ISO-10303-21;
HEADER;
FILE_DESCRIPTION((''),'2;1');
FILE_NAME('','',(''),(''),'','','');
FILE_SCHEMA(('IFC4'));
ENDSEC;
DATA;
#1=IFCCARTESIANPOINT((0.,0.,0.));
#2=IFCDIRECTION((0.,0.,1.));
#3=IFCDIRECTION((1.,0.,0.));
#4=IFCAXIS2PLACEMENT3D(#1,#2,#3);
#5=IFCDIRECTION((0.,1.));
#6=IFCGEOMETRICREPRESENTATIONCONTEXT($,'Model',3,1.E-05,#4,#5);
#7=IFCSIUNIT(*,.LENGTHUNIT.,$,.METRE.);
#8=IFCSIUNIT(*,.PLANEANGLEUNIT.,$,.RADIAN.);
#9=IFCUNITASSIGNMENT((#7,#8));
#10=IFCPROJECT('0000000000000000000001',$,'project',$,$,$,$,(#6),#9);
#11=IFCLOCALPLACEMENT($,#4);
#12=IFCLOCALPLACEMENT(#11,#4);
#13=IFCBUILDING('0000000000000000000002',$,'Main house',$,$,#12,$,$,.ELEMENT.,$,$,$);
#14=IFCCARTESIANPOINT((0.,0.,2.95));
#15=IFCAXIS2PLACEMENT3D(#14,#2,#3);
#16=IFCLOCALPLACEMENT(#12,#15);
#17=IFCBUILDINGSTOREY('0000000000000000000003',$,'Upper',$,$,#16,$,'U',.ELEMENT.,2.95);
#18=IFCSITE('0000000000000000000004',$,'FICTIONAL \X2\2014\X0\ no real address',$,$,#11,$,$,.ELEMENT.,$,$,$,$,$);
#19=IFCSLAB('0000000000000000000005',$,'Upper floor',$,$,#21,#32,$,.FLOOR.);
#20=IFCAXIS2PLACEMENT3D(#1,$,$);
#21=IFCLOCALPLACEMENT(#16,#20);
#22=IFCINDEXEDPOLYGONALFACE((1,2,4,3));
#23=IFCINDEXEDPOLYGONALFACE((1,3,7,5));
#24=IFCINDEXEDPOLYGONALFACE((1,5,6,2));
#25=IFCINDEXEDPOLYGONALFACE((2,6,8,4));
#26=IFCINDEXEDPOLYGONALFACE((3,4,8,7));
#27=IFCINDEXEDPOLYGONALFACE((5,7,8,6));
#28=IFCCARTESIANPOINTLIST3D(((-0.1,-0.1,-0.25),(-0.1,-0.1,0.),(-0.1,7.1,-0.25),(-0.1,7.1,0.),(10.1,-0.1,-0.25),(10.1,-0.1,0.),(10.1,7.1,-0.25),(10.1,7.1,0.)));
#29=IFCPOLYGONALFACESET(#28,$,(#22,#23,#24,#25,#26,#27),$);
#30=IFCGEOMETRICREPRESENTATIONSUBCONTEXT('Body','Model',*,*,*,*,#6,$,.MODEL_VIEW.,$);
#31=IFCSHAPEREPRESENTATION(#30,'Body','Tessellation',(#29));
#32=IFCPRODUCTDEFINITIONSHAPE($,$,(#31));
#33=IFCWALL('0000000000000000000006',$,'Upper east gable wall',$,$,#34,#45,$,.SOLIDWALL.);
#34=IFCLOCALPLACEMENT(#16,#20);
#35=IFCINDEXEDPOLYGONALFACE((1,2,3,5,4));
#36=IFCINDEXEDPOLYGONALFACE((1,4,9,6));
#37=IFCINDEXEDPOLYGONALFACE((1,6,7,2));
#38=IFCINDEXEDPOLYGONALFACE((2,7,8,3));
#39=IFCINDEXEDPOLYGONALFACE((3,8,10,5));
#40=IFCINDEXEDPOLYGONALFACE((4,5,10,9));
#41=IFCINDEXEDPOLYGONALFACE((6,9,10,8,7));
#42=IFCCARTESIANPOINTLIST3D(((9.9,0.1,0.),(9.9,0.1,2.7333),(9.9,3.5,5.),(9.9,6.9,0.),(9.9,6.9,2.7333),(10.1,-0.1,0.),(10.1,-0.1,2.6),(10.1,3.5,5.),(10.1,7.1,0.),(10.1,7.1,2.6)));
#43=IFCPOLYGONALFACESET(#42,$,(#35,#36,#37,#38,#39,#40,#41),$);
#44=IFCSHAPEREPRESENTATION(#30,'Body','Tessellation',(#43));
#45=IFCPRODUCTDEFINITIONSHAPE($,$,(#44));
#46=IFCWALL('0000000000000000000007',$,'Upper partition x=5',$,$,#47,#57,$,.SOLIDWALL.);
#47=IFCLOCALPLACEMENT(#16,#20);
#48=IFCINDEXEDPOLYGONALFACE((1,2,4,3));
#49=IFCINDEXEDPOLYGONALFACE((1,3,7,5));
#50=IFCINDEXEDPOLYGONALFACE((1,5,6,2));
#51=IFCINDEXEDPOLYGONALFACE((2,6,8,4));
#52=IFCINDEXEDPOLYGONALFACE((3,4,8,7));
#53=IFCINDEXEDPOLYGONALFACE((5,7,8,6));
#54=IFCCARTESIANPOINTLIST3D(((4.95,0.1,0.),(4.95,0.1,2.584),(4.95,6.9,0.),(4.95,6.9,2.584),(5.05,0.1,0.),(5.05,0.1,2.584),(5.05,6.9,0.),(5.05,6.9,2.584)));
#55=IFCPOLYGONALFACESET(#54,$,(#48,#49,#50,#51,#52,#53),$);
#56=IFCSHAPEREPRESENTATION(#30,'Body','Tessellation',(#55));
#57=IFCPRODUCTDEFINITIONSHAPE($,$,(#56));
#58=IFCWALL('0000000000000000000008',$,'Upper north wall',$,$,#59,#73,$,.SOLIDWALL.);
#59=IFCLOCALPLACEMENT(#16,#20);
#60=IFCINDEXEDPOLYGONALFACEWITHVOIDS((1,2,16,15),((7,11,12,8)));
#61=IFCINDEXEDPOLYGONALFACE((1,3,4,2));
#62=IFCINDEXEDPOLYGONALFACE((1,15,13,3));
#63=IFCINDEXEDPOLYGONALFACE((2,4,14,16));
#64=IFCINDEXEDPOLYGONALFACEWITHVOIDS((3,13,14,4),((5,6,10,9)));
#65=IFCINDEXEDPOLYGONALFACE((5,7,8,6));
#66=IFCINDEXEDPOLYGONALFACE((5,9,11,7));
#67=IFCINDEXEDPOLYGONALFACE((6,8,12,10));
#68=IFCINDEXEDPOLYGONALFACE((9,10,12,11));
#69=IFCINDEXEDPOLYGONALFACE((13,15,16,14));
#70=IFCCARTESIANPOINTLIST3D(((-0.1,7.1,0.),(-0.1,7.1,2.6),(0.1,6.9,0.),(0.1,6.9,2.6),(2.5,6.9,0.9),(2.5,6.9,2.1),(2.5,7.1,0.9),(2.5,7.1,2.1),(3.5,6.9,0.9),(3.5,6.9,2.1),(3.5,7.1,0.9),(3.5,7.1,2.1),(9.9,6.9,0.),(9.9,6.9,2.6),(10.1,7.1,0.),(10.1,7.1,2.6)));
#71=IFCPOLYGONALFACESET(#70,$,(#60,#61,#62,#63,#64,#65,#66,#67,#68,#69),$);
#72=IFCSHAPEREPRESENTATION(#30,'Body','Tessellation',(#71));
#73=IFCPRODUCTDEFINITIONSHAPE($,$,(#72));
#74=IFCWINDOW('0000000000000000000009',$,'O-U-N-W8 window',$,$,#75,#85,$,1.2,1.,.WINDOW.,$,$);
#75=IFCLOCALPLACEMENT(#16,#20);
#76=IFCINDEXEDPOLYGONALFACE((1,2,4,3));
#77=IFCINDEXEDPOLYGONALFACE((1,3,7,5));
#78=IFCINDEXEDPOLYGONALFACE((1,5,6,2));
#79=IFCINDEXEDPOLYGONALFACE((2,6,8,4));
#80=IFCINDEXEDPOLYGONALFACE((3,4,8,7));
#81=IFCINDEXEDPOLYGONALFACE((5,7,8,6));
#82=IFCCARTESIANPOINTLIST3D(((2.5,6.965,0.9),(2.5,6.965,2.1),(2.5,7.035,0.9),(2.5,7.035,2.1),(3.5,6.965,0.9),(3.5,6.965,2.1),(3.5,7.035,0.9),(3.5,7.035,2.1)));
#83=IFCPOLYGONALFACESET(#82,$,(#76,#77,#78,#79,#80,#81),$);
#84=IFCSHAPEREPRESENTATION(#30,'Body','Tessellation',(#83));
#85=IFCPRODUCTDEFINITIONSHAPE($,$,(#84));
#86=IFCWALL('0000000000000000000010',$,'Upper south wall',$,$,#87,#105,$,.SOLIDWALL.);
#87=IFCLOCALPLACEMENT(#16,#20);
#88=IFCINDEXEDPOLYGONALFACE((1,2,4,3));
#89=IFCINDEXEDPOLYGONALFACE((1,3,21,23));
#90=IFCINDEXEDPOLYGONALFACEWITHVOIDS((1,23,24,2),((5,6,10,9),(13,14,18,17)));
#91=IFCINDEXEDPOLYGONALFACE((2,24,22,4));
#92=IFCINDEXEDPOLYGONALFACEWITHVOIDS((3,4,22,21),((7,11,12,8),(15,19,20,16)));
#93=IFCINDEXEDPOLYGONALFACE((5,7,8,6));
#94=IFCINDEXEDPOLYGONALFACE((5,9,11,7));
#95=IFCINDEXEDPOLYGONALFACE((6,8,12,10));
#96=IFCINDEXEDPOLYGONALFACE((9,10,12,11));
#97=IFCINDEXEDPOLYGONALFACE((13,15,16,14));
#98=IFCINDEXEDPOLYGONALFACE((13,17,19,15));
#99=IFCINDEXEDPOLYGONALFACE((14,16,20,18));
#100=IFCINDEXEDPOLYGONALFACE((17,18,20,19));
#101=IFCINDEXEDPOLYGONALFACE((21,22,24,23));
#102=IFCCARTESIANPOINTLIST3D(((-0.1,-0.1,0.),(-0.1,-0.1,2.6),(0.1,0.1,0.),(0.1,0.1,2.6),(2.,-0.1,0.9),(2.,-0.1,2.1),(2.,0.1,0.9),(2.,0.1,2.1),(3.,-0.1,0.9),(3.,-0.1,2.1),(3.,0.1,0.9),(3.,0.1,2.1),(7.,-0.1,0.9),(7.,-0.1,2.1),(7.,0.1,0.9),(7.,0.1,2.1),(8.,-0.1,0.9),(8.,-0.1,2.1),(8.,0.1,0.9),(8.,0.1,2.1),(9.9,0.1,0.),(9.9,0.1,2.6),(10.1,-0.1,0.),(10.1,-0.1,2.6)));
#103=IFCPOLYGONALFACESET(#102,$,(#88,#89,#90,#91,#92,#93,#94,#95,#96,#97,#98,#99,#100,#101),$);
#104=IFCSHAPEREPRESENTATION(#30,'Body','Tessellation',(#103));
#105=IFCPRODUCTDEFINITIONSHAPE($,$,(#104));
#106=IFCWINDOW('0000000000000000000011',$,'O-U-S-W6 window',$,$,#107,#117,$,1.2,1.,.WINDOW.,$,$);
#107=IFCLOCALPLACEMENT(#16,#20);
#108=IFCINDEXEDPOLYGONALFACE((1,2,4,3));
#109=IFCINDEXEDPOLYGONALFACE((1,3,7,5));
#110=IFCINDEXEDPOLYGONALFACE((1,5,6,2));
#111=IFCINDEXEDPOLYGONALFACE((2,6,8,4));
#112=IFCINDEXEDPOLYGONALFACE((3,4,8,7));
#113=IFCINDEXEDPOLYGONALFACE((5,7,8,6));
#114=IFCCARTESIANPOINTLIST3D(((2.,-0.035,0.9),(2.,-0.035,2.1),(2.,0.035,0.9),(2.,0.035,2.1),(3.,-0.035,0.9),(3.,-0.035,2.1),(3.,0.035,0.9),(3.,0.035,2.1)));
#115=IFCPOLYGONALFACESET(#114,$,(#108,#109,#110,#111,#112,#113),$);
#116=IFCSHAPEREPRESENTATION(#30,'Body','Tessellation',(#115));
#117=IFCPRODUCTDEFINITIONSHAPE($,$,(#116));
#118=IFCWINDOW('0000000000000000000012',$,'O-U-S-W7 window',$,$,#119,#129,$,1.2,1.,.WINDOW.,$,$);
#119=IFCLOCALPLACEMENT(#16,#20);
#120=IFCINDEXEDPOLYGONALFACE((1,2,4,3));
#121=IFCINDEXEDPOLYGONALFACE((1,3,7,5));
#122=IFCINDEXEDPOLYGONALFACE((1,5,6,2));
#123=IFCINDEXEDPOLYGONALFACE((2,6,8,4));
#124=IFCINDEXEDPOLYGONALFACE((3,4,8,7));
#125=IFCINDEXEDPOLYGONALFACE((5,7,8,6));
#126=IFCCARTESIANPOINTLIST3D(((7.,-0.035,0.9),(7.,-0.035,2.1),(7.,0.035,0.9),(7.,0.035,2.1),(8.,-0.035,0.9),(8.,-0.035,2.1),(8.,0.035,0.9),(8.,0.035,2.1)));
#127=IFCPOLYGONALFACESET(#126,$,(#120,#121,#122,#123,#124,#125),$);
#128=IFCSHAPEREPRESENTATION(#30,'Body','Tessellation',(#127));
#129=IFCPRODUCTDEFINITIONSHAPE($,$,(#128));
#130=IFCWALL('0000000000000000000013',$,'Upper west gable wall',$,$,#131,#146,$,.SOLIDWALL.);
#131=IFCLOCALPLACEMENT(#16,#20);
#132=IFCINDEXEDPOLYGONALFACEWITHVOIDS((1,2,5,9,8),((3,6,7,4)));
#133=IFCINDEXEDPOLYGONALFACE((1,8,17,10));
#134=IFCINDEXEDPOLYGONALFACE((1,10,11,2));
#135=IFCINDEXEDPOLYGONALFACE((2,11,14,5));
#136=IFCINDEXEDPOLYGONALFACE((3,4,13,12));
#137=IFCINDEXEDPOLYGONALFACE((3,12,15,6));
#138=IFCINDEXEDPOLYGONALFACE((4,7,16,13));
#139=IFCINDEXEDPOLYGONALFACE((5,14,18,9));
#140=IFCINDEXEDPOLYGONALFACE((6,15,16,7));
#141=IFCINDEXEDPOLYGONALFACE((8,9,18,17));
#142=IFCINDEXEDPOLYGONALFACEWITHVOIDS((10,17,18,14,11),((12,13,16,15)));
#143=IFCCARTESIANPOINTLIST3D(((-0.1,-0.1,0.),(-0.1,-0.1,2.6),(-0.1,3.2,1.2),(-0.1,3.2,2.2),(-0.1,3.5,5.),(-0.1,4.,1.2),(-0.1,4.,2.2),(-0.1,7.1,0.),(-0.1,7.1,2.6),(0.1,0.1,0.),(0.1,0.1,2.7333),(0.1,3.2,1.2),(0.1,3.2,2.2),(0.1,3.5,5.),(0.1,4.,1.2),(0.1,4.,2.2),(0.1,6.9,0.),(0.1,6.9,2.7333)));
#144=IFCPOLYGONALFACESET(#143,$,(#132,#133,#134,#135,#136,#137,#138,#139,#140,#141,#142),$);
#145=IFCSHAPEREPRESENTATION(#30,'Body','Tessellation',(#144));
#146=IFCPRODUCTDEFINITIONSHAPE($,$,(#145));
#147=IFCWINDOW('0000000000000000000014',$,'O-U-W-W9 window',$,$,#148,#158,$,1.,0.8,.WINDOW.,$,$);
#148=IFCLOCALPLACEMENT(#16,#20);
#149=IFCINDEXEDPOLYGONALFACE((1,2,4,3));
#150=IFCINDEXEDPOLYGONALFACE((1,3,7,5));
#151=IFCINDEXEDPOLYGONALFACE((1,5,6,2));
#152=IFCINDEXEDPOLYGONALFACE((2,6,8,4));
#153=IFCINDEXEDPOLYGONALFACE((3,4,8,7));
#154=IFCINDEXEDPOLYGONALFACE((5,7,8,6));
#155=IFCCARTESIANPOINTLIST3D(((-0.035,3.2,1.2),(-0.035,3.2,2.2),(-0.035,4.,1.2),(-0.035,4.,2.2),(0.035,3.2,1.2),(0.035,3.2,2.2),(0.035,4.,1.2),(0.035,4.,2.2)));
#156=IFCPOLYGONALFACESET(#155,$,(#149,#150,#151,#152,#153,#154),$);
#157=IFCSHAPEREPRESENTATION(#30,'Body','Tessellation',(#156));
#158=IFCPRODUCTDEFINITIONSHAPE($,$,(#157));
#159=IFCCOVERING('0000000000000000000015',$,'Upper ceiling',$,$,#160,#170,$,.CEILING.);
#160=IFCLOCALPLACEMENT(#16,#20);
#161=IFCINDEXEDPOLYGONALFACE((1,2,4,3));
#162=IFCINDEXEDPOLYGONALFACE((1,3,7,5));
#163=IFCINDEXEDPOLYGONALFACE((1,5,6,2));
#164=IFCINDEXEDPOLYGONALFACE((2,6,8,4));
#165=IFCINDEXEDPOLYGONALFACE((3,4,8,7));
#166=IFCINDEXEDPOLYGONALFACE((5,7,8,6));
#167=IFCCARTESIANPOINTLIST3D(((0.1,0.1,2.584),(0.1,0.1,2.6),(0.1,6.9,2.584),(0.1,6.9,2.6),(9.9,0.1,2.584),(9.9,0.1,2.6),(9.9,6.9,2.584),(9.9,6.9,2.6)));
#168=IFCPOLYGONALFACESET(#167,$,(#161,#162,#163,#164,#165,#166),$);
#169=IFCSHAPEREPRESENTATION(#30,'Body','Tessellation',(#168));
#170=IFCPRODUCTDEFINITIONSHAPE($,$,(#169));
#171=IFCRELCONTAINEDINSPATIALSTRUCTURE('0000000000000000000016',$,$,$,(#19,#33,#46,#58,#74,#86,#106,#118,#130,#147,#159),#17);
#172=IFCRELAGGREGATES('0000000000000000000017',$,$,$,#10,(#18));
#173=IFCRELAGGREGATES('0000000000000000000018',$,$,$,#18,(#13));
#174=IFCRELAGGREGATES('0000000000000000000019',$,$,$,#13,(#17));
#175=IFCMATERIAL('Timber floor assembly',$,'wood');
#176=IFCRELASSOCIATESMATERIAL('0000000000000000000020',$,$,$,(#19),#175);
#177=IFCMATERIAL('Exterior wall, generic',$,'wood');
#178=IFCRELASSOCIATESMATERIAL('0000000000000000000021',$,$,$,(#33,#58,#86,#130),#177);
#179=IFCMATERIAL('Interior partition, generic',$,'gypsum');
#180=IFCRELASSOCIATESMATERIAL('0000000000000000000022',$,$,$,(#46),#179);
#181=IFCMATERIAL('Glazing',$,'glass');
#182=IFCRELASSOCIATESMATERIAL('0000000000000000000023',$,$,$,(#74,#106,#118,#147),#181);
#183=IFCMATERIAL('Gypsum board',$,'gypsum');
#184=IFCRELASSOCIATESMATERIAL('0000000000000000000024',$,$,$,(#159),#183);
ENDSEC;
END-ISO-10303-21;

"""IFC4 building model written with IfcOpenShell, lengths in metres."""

from ifc_helpers import new_model, si_unit, direction, frame, origin_with_axes, place, context, subcontext, project, spatial, polyline, outline, extrude, clip, halfspace, material, element, fill, save


model = new_model("IFC4")

# Units and contexts
model_context = context("Model", 3, precision=1e-05, world=origin_with_axes(), true_north=direction((0.0, 1.0)))
body_context = subcontext(model_context, "Body", "Model", "MODEL_VIEW")
ifc_project = project(units=[si_unit("LENGTHUNIT", "METRE"), si_unit("PLANEANGLEUNIT", "RADIAN")], contexts=[model_context])

# Site, building, storey
site_placement = place(None, origin_with_axes())
site = spatial("IfcSite", under=ifc_project, at=site_placement, Name="FICTIONAL — no real address", CompositionType="ELEMENT")
building_placement = place(site_placement, origin_with_axes())
building = spatial("IfcBuilding", under=site, at=building_placement, Name="Main house", CompositionType="ELEMENT")
storey_placement = place(building_placement, frame((0.0, 0.0, 2.95), z_axis=(0.0, 0.0, 1.0), x_axis=(1.0, 0.0, 0.0)))
storey = spatial("IfcBuildingStorey", under=building, at=storey_placement, Name="Upper", LongName="U", CompositionType="ELEMENT", Elevation=2.95)

# Slab
ifc_material_1 = material(Name="Timber floor assembly", Category="wood")
slab_1_placement = place(storey_placement, origin_with_axes())
element("IfcSlab", 1, at=slab_1_placement, inside=storey, material=ifc_material_1, Name="Upper floor", PredefinedType="FLOOR", context=body_context, shape_type="SweptSolid", body=[
    extrude(outline(polyline([(-0.1, -0.1), (10.1, -0.1), (10.1, 7.1), (-0.1, 7.1), (-0.1, -0.1)])), frame((0.0, 0.0, -0.25), z_axis=(0.0, 0.0, 1.0), x_axis=(1.0, 0.0, 0.0)), (0.0, 0.0, 1.0), 0.25),
])

# Walls
ifc_material_2 = material(Name="Exterior wall, generic", Category="wood")
wall_1_placement = place(storey_placement, origin_with_axes())
element("IfcWall", 2, at=wall_1_placement, inside=storey, material=ifc_material_2, Name="Upper east gable wall", PredefinedType="SOLIDWALL", context=body_context, shape_type="Clipping", body=[
    clip(clip(extrude(outline(polyline([(10.1, -0.1), (10.1, 7.1), (9.9, 6.9), (9.9, 0.1), (10.1, -0.1)])), origin_with_axes(), (0.0, 0.0, 1.0), 6.2404), halfspace(frame((0.0, 0.0, 2.6667), z_axis=(0.0, -0.5547, 0.83205), x_axis=(1.0, 0.0, 0.0)), False)), halfspace(frame((0.0, 0.0, 7.3333), z_axis=(0.0, 0.5547, 0.83205), x_axis=(1.0, 0.0, 0.0)), False)),
])
ifc_material_3 = material(Name="Interior partition, generic", Category="gypsum")
wall_2_placement = place(storey_placement, origin_with_axes())
element("IfcWall", 3, at=wall_2_placement, inside=storey, material=ifc_material_3, Name="Upper partition x=5", PredefinedType="SOLIDWALL", context=body_context, shape_type="SweptSolid", body=[
    extrude(outline(polyline([(5.05, 0.1), (5.05, 6.9), (4.95, 6.9), (4.95, 0.1), (5.05, 0.1)])), origin_with_axes(), (0.0, 0.0, 1.0), 2.584),
])

# Wall, opening, window
wall_3_placement = place(storey_placement, origin_with_axes())
wall_3 = element("IfcWall", 4, at=wall_3_placement, inside=storey, material=ifc_material_2, Name="Upper north wall", PredefinedType="SOLIDWALL", context=body_context, shape_type="SweptSolid", body=[
    extrude(outline(polyline([(10.1, 7.1), (-0.1, 7.1), (0.1, 6.9), (9.9, 6.9), (10.1, 7.1)])), origin_with_axes(), (0.0, 0.0, 1.0), 2.6),
])
opening_1_placement = place(storey_placement, origin_with_axes())
opening_1 = element("IfcOpeningElement", 5, at=opening_1_placement, cuts=wall_3, PredefinedType="OPENING", context=body_context, shape_type="SweptSolid", body=[
    extrude(outline(polyline([(3.5, 7.105), (2.5, 7.105), (2.5, 6.895), (3.5, 6.895), (3.5, 7.105)])), frame((0.0, 0.0, 0.9), z_axis=(0.0, 0.0, 1.0), x_axis=(1.0, 0.0, 0.0)), (0.0, 0.0, 1.0), 1.2),
])
ifc_material_4 = material(Name="Glazing", Category="glass")
window_1_placement = place(storey_placement, origin_with_axes())
window_1 = element("IfcWindow", 6, at=window_1_placement, inside=storey, material=ifc_material_4, Name="O-U-N-W8 window", OverallHeight=1.2, OverallWidth=1.0, PredefinedType="WINDOW", context=body_context, shape_type="SweptSolid", body=[
    extrude(outline(polyline([(3.5, 7.035), (2.5, 7.035), (2.5, 6.965), (3.5, 6.965), (3.5, 7.035)])), frame((0.0, 0.0, 0.9), z_axis=(0.0, 0.0, 1.0), x_axis=(1.0, 0.0, 0.0)), (0.0, 0.0, 1.0), 1.2),
])
fill(opening_1, window_1)

# Wall, openings, windows
wall_4_placement = place(storey_placement, origin_with_axes())
wall_4 = element("IfcWall", 7, at=wall_4_placement, inside=storey, material=ifc_material_2, Name="Upper south wall", PredefinedType="SOLIDWALL", context=body_context, shape_type="SweptSolid", body=[
    extrude(outline(polyline([(-0.1, -0.1), (10.1, -0.1), (9.9, 0.1), (0.1, 0.1), (-0.1, -0.1)])), origin_with_axes(), (0.0, 0.0, 1.0), 2.6),
])
opening_2_placement = place(storey_placement, origin_with_axes())
opening_2 = element("IfcOpeningElement", 8, at=opening_2_placement, cuts=wall_4, PredefinedType="OPENING", context=body_context, shape_type="SweptSolid", body=[
    extrude(outline(polyline([(2.0, -0.105), (3.0, -0.105), (3.0, 0.105), (2.0, 0.105), (2.0, -0.105)])), frame((0.0, 0.0, 0.9), z_axis=(0.0, 0.0, 1.0), x_axis=(1.0, 0.0, 0.0)), (0.0, 0.0, 1.0), 1.2),
])
opening_3_placement = place(storey_placement, origin_with_axes())
opening_3 = element("IfcOpeningElement", 9, at=opening_3_placement, cuts=wall_4, PredefinedType="OPENING", context=body_context, shape_type="SweptSolid", body=[
    extrude(outline(polyline([(7.0, -0.105), (8.0, -0.105), (8.0, 0.105), (7.0, 0.105), (7.0, -0.105)])), frame((0.0, 0.0, 0.9), z_axis=(0.0, 0.0, 1.0), x_axis=(1.0, 0.0, 0.0)), (0.0, 0.0, 1.0), 1.2),
])
window_2_placement = place(storey_placement, origin_with_axes())
window_2 = element("IfcWindow", 10, at=window_2_placement, inside=storey, material=ifc_material_4, Name="O-U-S-W6 window", OverallHeight=1.2, OverallWidth=1.0, PredefinedType="WINDOW", context=body_context, shape_type="SweptSolid", body=[
    extrude(outline(polyline([(2.0, -0.035), (3.0, -0.035), (3.0, 0.035), (2.0, 0.035), (2.0, -0.035)])), frame((0.0, 0.0, 0.9), z_axis=(0.0, 0.0, 1.0), x_axis=(1.0, 0.0, 0.0)), (0.0, 0.0, 1.0), 1.2),
])
fill(opening_2, window_2)
window_3_placement = place(storey_placement, origin_with_axes())
window_3 = element("IfcWindow", 11, at=window_3_placement, inside=storey, material=ifc_material_4, Name="O-U-S-W7 window", OverallHeight=1.2, OverallWidth=1.0, PredefinedType="WINDOW", context=body_context, shape_type="SweptSolid", body=[
    extrude(outline(polyline([(7.0, -0.035), (8.0, -0.035), (8.0, 0.035), (7.0, 0.035), (7.0, -0.035)])), frame((0.0, 0.0, 0.9), z_axis=(0.0, 0.0, 1.0), x_axis=(1.0, 0.0, 0.0)), (0.0, 0.0, 1.0), 1.2),
])
fill(opening_3, window_3)

# Wall, opening, window
wall_5_placement = place(storey_placement, origin_with_axes())
wall_5 = element("IfcWall", 12, at=wall_5_placement, inside=storey, material=ifc_material_2, Name="Upper west gable wall", PredefinedType="SOLIDWALL", context=body_context, shape_type="Clipping", body=[
    clip(clip(extrude(outline(polyline([(-0.1, 7.1), (-0.1, -0.1), (0.1, 0.1), (0.1, 6.9), (-0.1, 7.1)])), origin_with_axes(), (0.0, 0.0, 1.0), 6.2404), halfspace(frame((0.0, 0.0, 2.6667), z_axis=(0.0, -0.5547, 0.83205), x_axis=(1.0, 0.0, 0.0)), False)), halfspace(frame((0.0, 0.0, 7.3333), z_axis=(0.0, 0.5547, 0.83205), x_axis=(1.0, 0.0, 0.0)), False)),
])
opening_4_placement = place(storey_placement, origin_with_axes())
opening_4 = element("IfcOpeningElement", 13, at=opening_4_placement, cuts=wall_5, PredefinedType="OPENING", context=body_context, shape_type="SweptSolid", body=[
    extrude(outline(polyline([(-0.105, 4.0), (-0.105, 3.2), (0.105, 3.2), (0.105, 4.0), (-0.105, 4.0)])), frame((0.0, 0.0, 1.2), z_axis=(0.0, 0.0, 1.0), x_axis=(1.0, 0.0, 0.0)), (0.0, 0.0, 1.0), 1.0),
])
window_4_placement = place(storey_placement, origin_with_axes())
window_4 = element("IfcWindow", 14, at=window_4_placement, inside=storey, material=ifc_material_4, Name="O-U-W-W9 window", OverallHeight=1.0, OverallWidth=0.8, PredefinedType="WINDOW", context=body_context, shape_type="SweptSolid", body=[
    extrude(outline(polyline([(-0.035, 4.0), (-0.035, 3.2), (0.035, 3.2), (0.035, 4.0), (-0.035, 4.0)])), frame((0.0, 0.0, 1.2), z_axis=(0.0, 0.0, 1.0), x_axis=(1.0, 0.0, 0.0)), (0.0, 0.0, 1.0), 1.0),
])
fill(opening_4, window_4)

# Covering
ifc_material_5 = material(Name="Gypsum board", Category="gypsum")
covering_placement = place(storey_placement, origin_with_axes())
element("IfcCovering", 15, at=covering_placement, inside=storey, material=ifc_material_5, Name="Upper ceiling", PredefinedType="CEILING", context=body_context, shape_type="SweptSolid", body=[
    extrude(outline(polyline([(0.1, 0.1), (9.9, 0.1), (9.9, 6.9), (0.1, 6.9), (0.1, 0.1)])), frame((0.0, 0.0, 2.584), z_axis=(0.0, 0.0, 1.0), x_axis=(1.0, 0.0, 0.0)), (0.0, 0.0, 1.0), 0.016),
])

save(model, "model.ifc")
